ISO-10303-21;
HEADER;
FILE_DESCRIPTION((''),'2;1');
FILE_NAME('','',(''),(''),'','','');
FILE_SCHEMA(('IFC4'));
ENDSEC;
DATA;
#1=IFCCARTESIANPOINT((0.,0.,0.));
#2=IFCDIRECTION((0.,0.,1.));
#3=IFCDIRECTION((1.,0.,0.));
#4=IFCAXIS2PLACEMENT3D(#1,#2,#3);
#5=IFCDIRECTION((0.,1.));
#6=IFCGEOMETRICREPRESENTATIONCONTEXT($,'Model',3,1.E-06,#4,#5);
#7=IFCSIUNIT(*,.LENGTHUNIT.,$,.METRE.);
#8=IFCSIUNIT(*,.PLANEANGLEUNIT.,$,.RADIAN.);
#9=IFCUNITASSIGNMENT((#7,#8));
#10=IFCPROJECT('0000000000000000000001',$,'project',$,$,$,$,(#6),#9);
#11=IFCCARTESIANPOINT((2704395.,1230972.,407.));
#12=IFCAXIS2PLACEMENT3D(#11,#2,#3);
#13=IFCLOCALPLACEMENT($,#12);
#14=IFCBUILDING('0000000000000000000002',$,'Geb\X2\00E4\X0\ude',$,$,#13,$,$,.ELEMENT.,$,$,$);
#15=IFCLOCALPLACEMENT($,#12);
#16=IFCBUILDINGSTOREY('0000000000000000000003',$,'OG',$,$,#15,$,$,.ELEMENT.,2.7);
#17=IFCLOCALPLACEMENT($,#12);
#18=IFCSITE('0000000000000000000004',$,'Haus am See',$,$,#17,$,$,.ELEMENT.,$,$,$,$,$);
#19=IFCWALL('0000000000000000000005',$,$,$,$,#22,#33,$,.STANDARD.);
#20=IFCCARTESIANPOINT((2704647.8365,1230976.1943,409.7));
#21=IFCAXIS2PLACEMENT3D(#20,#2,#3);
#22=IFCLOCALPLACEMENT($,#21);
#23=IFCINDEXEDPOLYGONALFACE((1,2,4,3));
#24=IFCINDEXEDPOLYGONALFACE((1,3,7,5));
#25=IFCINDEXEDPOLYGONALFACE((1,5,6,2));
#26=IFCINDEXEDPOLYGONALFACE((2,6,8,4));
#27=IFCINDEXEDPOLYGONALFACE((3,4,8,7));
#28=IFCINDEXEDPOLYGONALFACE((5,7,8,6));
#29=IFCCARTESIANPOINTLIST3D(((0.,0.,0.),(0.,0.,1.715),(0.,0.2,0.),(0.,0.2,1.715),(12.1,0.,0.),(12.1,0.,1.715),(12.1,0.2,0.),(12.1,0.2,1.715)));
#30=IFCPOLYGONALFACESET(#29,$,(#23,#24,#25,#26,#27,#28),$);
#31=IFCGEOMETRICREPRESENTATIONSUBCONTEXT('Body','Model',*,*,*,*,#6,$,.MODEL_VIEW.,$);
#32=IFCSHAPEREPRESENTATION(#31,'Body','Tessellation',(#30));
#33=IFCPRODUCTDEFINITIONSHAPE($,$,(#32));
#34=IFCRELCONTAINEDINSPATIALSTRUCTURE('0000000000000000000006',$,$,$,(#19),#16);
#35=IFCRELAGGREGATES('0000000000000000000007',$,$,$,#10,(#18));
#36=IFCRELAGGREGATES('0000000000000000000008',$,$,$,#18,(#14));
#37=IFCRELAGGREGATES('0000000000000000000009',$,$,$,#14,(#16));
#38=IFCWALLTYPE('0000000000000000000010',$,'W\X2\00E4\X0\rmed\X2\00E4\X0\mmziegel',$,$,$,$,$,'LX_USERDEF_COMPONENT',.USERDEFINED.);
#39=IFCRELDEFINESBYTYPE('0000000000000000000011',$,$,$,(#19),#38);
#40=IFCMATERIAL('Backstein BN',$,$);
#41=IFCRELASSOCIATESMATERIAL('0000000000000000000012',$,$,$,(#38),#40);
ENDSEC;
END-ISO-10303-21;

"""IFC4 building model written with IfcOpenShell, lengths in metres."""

from ifc_helpers import new_model, si_unit, direction, frame, origin_with_axes, place, context, subcontext, project, spatial, polyline, outline, extrude, material, type_object, element, save


model = new_model("IFC4")

# Units and contexts
model_context = context("Model", 3, precision=1e-06, world=origin_with_axes(), true_north=direction((0.0, 1.0)))
body_context = subcontext(model_context, "Body", "Model", "MODEL_VIEW")
ifc_project = project(units=[si_unit("LENGTHUNIT", "METRE"), si_unit("PLANEANGLEUNIT", "RADIAN")], contexts=[model_context])

# Site, building, storey
site_placement = place(None, frame((2704395.0, 1230972.0, 407.0), z_axis=(0.0, 0.0, 1.0), x_axis=(1.0, 0.0, 0.0)))
site = spatial("IfcSite", under=ifc_project, at=site_placement, Name="Haus am See", CompositionType="ELEMENT")
building_placement = place(None, frame((2704395.0, 1230972.0, 407.0), z_axis=(0.0, 0.0, 1.0), x_axis=(1.0, 0.0, 0.0)))
building = spatial("IfcBuilding", under=site, at=building_placement, Name="Gebäude", CompositionType="ELEMENT")
storey_placement = place(None, frame((2704395.0, 1230972.0, 407.0), z_axis=(0.0, 0.0, 1.0), x_axis=(1.0, 0.0, 0.0)))
storey = spatial("IfcBuildingStorey", under=building, at=storey_placement, Name="OG", CompositionType="ELEMENT", Elevation=2.7)

# Wall
ifc_material_1 = material(Name="Backstein BN")
wall_type = type_object("IfcWallType", Name="Wärmedämmziegel", ElementType="LX_USERDEF_COMPONENT", PredefinedType="USERDEFINED", material=ifc_material_1)
wall_1_placement = place(None, frame((2704647.8365, 1230976.1943, 409.7), z_axis=(0.0, 0.0, 1.0), x_axis=(1.0, 0.0, 0.0)))
element("IfcWall", 1, at=wall_1_placement, inside=storey, type_object=wall_type, PredefinedType="STANDARD", context=body_context, shape_type="SweptSolid", body=[
    extrude(outline(polyline([(0.0, 0.0, 0.0), (12.1, 0.0, 0.0), (12.1, 0.2, 0.0), (0.0, 0.2, 0.0), (0.0, 0.0, 0.0)])), origin_with_axes(), (0.0, 0.0, 1.0), 1.715),
])

save(model, "model.ifc")
